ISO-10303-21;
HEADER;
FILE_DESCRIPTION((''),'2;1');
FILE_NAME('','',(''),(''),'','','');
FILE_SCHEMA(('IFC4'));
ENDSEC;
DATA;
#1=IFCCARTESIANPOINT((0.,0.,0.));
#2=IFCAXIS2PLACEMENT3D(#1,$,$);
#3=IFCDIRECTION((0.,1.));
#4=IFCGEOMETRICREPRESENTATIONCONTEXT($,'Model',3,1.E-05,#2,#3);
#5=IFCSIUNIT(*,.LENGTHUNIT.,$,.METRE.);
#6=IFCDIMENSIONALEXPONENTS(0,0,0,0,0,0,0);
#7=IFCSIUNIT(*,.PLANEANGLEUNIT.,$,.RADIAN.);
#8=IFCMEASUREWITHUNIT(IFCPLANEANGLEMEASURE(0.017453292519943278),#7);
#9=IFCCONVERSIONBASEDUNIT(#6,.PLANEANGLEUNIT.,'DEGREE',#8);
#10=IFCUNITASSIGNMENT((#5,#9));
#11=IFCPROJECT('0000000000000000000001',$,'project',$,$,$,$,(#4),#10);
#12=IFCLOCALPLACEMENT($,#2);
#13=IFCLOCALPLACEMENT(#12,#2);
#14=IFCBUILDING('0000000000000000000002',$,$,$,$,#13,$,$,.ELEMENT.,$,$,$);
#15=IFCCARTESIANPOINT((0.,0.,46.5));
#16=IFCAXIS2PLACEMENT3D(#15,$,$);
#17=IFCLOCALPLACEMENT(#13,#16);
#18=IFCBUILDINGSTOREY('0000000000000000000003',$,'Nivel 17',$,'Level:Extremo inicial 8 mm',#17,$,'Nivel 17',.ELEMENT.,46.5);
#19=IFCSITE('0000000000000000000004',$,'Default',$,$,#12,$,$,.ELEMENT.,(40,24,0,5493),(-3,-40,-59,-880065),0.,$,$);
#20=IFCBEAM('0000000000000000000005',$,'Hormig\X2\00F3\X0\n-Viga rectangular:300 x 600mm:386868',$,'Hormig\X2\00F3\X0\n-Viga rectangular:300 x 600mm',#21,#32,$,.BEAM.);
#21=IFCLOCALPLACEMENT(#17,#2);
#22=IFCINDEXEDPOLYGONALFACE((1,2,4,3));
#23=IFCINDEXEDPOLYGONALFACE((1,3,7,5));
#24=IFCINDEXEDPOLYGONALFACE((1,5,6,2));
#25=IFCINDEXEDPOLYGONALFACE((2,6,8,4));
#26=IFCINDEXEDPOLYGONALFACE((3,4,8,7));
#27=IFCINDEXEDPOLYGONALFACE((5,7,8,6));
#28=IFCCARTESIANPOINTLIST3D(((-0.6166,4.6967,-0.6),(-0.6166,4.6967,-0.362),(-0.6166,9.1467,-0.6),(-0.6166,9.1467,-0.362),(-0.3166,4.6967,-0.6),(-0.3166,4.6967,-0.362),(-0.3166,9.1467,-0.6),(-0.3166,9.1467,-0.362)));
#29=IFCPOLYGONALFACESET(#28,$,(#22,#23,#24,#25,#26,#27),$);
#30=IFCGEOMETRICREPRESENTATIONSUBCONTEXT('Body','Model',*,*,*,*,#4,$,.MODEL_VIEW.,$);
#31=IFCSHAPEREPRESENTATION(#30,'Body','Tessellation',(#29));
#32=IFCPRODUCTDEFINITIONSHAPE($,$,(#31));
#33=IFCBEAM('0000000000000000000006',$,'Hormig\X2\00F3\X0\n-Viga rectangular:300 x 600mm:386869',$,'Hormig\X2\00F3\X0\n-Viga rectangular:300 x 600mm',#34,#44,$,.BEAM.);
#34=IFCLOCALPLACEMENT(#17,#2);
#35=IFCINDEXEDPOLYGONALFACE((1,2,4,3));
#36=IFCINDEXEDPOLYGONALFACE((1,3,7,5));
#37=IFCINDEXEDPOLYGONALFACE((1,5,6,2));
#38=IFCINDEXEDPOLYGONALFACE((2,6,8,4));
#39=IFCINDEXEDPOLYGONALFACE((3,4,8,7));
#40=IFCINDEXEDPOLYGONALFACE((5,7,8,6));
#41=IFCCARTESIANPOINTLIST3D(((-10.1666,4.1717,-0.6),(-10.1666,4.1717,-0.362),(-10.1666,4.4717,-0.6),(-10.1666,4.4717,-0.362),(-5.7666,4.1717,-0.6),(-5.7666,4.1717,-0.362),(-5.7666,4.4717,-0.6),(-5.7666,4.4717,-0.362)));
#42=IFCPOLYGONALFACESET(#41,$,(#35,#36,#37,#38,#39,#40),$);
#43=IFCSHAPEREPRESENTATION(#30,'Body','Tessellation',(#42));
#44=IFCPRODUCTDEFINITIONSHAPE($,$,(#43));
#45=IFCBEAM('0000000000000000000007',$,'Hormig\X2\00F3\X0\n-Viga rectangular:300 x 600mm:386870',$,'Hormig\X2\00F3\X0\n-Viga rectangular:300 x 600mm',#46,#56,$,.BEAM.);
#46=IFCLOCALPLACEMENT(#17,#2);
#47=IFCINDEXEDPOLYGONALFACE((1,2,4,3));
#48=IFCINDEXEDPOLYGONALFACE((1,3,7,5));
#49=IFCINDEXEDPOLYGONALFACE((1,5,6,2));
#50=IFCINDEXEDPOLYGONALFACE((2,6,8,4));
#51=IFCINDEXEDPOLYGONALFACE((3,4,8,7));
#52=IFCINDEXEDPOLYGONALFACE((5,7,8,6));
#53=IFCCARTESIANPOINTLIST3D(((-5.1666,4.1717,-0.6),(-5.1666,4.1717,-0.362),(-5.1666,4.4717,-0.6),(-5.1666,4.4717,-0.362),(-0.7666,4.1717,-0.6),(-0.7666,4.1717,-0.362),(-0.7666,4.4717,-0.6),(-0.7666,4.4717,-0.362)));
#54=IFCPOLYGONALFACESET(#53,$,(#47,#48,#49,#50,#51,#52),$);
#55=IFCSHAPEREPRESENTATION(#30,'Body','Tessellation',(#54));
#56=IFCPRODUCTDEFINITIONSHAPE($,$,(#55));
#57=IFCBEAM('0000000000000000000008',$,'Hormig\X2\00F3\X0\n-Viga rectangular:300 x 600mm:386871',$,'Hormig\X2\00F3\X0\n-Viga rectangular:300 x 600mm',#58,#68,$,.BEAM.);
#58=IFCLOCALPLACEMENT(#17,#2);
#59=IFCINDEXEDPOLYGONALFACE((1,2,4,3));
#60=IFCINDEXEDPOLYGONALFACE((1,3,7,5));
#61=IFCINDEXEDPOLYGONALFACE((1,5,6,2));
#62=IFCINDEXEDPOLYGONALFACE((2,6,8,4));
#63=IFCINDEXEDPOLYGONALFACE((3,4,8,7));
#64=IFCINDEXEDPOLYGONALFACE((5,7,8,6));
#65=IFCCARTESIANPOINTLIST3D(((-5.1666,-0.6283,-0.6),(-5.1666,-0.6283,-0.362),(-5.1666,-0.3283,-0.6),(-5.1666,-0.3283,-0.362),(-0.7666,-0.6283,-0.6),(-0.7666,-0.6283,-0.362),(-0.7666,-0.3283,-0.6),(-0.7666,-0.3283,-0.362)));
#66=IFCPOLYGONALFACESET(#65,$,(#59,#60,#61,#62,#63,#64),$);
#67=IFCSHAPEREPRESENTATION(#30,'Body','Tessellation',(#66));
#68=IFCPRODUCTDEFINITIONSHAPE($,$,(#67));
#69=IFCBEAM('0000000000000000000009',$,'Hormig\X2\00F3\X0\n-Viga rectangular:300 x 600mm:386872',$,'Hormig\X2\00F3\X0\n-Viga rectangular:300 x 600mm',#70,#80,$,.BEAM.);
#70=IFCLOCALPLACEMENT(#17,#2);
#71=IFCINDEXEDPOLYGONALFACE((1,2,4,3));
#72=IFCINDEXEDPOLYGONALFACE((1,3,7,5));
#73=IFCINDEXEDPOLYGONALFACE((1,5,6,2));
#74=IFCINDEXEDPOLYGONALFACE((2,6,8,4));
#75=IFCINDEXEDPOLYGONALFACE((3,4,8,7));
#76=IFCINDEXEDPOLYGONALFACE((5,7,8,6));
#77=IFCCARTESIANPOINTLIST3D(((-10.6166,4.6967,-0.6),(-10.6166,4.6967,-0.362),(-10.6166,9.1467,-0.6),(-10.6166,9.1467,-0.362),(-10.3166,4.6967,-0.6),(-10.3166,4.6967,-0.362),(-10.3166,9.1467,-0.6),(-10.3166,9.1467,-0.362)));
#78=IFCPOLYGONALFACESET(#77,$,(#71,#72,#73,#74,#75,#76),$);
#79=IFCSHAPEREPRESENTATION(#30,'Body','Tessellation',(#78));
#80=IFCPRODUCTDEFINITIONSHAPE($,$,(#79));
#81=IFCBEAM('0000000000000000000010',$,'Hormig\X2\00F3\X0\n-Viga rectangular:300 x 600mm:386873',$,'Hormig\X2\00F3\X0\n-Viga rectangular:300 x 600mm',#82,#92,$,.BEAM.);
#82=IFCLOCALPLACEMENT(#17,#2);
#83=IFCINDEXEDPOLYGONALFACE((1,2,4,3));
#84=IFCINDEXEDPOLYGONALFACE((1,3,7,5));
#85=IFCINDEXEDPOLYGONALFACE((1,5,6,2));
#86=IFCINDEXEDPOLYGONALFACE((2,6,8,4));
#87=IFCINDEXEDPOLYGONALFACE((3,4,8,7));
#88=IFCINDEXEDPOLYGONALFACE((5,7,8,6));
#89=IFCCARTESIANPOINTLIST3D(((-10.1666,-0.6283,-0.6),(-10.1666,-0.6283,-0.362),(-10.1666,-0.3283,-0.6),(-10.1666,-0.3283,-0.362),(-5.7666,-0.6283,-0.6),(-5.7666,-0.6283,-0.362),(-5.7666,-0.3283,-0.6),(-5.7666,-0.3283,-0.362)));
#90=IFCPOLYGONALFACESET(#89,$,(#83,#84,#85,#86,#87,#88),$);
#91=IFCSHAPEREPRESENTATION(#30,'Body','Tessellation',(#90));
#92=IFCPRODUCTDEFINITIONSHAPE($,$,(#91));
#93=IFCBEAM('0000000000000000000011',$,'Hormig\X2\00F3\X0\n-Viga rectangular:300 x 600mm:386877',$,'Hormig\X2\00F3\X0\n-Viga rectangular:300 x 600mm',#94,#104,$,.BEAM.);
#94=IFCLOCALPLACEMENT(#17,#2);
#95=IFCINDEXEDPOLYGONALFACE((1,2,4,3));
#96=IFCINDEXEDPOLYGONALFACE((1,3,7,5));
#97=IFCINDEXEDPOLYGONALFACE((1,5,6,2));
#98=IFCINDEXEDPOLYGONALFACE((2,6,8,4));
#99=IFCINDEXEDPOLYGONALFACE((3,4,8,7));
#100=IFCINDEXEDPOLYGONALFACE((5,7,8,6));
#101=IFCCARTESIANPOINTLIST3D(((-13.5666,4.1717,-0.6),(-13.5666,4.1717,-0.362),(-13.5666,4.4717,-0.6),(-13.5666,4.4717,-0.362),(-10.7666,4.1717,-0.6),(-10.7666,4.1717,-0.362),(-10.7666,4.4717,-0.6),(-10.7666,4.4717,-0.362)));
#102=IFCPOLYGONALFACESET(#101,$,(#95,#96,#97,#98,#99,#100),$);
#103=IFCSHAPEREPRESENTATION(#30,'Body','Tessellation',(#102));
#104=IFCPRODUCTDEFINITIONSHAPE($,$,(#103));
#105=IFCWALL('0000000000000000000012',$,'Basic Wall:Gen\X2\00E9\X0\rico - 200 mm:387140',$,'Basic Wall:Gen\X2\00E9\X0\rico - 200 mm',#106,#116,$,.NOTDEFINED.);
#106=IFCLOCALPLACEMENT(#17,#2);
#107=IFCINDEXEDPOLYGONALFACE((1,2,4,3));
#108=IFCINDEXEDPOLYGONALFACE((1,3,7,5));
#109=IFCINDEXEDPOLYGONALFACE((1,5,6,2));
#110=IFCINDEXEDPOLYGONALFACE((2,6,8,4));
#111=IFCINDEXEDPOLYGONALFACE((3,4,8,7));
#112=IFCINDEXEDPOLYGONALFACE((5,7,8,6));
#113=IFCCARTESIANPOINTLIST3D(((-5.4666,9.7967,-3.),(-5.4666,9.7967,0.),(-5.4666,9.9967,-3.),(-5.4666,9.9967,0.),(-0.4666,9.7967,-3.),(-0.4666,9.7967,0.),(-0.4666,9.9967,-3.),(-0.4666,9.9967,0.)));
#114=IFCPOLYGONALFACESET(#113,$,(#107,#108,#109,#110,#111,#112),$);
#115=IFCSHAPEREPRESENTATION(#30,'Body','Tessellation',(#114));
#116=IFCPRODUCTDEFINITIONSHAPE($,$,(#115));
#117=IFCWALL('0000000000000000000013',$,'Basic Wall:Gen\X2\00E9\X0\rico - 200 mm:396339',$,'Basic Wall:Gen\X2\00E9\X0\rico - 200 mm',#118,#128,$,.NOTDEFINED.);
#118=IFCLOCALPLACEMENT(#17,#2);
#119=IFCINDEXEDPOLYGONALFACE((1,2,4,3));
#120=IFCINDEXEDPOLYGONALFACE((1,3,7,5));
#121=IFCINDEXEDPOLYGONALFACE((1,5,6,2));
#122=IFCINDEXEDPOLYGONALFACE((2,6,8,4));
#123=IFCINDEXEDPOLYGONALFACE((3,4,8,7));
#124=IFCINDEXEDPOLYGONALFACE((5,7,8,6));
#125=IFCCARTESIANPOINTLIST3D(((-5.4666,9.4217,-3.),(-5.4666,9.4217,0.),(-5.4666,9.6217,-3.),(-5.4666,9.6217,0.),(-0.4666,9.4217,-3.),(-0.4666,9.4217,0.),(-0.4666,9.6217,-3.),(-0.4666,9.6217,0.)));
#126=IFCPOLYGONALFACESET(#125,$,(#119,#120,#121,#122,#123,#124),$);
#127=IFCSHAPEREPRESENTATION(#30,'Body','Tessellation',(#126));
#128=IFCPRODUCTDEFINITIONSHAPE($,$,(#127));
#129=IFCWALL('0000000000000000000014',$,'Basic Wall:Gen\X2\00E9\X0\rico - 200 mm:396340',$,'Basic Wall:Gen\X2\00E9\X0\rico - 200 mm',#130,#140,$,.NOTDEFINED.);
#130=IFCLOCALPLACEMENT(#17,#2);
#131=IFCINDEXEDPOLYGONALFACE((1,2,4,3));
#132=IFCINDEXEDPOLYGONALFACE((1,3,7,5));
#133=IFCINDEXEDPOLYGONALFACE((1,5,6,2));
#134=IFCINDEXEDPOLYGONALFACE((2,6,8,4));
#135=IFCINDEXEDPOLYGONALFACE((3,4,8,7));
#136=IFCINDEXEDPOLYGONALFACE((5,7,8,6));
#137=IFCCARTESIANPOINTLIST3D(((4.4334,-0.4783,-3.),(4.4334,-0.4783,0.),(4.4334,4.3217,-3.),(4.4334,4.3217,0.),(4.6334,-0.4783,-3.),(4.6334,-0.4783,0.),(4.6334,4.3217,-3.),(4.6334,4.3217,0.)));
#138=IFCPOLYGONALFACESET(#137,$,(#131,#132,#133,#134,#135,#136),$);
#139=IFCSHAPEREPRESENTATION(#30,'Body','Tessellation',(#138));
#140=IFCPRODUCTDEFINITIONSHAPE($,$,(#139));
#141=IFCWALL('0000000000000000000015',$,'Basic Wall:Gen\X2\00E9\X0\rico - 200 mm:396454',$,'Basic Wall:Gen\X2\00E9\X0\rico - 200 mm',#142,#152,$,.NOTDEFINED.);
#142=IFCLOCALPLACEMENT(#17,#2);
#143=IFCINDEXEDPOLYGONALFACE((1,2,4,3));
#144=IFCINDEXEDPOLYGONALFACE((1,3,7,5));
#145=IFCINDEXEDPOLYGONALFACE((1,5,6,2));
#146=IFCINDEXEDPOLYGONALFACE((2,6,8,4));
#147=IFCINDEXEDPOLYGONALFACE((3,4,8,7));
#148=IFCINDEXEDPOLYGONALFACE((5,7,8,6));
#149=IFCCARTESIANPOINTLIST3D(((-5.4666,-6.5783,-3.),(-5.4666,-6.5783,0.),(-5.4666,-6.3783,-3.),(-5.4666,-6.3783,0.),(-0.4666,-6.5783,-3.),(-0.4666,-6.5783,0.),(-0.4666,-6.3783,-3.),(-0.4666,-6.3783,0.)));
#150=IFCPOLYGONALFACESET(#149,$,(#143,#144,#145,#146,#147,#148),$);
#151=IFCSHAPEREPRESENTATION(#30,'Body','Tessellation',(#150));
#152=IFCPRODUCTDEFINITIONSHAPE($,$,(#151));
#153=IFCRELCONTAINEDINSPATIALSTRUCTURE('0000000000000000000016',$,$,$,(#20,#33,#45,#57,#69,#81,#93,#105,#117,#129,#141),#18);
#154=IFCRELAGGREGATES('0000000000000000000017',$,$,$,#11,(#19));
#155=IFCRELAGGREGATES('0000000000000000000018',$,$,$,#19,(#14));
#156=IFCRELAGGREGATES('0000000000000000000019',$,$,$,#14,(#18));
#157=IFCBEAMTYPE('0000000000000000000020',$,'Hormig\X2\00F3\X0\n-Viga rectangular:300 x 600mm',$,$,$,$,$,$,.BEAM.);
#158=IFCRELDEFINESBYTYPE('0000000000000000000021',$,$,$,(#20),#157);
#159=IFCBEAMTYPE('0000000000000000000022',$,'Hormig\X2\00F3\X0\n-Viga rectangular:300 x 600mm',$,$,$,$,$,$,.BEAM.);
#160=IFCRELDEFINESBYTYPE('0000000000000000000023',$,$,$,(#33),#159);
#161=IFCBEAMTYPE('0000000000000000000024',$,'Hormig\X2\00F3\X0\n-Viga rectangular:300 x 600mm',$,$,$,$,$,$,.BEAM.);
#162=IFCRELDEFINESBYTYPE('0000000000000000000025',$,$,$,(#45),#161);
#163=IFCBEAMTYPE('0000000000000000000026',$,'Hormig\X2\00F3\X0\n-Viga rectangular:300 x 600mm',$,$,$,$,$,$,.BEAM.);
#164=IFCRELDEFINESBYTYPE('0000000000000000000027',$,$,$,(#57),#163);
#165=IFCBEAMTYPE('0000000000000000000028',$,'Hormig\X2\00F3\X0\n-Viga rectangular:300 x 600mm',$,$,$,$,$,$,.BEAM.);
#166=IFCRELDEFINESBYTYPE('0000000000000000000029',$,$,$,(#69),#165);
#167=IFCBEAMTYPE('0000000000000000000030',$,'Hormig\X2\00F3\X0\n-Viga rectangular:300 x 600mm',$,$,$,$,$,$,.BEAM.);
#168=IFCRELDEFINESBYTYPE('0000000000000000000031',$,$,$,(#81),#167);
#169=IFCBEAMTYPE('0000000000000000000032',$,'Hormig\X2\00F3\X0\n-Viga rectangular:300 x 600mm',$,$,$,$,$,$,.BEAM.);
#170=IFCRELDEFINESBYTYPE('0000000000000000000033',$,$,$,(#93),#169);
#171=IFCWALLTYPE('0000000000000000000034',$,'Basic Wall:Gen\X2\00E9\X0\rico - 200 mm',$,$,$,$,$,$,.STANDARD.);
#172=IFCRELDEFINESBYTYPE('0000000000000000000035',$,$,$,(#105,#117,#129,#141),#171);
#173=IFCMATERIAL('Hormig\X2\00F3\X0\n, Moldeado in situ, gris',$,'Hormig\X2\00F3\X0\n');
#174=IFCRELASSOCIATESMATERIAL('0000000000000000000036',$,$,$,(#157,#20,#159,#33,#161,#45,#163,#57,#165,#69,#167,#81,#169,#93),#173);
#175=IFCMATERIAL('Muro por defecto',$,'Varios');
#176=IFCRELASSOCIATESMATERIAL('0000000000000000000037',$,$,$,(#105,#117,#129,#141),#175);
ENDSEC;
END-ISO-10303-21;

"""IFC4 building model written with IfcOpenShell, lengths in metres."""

from ifc_helpers import new_model, entity, si_unit, converted_unit, direction, frame, origin, place, context, subcontext, project, spatial, indexed_curve, outline, extrude, source, transform, mapped, material, type_object, type_shapes, element, save


model = new_model("IFC4")

# Units and contexts
model_context = context("Model", 3, precision=1e-05, world=origin(), true_north=direction((0.0, 1.0)))
body_context = subcontext(model_context, "Body", "Model", "MODEL_VIEW")
ifc_project = project(units=[si_unit("LENGTHUNIT", "METRE"), converted_unit("PLANEANGLEUNIT", "DEGREE", entity("IfcPlaneAngleMeasure", 0.017453292519943278), si_unit("PLANEANGLEUNIT", "RADIAN"), dimensions=[0, 0, 0, 0, 0, 0, 0])], contexts=[model_context])

# Site, building, storey
site_placement = place(None, origin())
site = spatial("IfcSite", under=ifc_project, at=site_placement, Name="Default", CompositionType="ELEMENT", RefLatitude=(40, 24, 0, 5493), RefLongitude=(-3, -40, -59, -880065), RefElevation=0.0)
building_placement = place(site_placement, origin())
building = spatial("IfcBuilding", under=site, at=building_placement, CompositionType="ELEMENT")
storey_placement = place(building_placement, frame((0.0, 0.0, 46.5)))
storey = spatial("IfcBuildingStorey", under=building, at=storey_placement, Name="Nivel 17", ObjectType="Level:Extremo inicial 8 mm", LongName="Nivel 17", CompositionType="ELEMENT", Elevation=46.5)

# Beams
ifc_material_1 = material(Name="Hormigón, Moldeado in situ, gris", Category="Hormigón")
beam_type_1 = type_object("IfcBeamType", Name="Hormigón-Viga rectangular:300 x 600mm", PredefinedType="BEAM", material=ifc_material_1)
shared_shape_1 = source(origin(), body_context, "Body", "SweptSolid", [
    extrude(outline(indexed_curve([(-0.15, -0.119), (0.15, -0.119), (0.15, 0.119), (-0.15, 0.119), (-0.15, -0.119)], self_intersect=False)), frame((-0.4666, 9.1467, 46.019), z_axis=(0.0, -1.0, 0.0), x_axis=(-1.0, 0.0, 0.0)), (0.0, 0.0, 1.0), 4.45),
])
type_shapes(beam_type_1, [shared_shape_1])
beam_1_placement = place(storey_placement, frame((0.0, 0.0, -46.5)))
element("IfcBeam", 1, at=beam_1_placement, inside=storey, type_object=beam_type_1, material=ifc_material_1, Name="Hormigón-Viga rectangular:300 x 600mm:386868", ObjectType="Hormigón-Viga rectangular:300 x 600mm", PredefinedType="BEAM", context=body_context, shape_type="MappedRepresentation", body=[
    mapped(shared_shape_1, transform((0.0, 0.0, 0.0), scale=1.0)),
])
beam_type_2 = type_object("IfcBeamType", Name="Hormigón-Viga rectangular:300 x 600mm", PredefinedType="BEAM", material=ifc_material_1)
shared_shape_2 = source(origin(), body_context, "Body", "SweptSolid", [
    extrude(outline(indexed_curve([(-0.119, -0.15), (0.119, -0.15), (0.119, 0.15), (-0.119, 0.15), (-0.119, -0.15)], self_intersect=False)), frame((-10.1666, 4.3217, 46.019), z_axis=(1.0, 0.0, 0.0), x_axis=(0.0, 0.0, -1.0)), (0.0, 0.0, 1.0), 4.4),
])
type_shapes(beam_type_2, [shared_shape_2])
beam_2_placement = place(storey_placement, frame((0.0, 0.0, -46.5)))
element("IfcBeam", 2, at=beam_2_placement, inside=storey, type_object=beam_type_2, material=ifc_material_1, Name="Hormigón-Viga rectangular:300 x 600mm:386869", ObjectType="Hormigón-Viga rectangular:300 x 600mm", PredefinedType="BEAM", context=body_context, shape_type="MappedRepresentation", body=[
    mapped(shared_shape_2, transform((0.0, 0.0, 0.0), scale=1.0)),
])
beam_type_3 = type_object("IfcBeamType", Name="Hormigón-Viga rectangular:300 x 600mm", PredefinedType="BEAM", material=ifc_material_1)
shared_shape_3 = source(origin(), body_context, "Body", "SweptSolid", [
    extrude(outline(indexed_curve([(-0.119, -0.15), (0.119, -0.15), (0.119, 0.15), (-0.119, 0.15), (-0.119, -0.15)], self_intersect=False)), frame((-5.1666, 4.3217, 46.019), z_axis=(1.0, 0.0, 0.0), x_axis=(0.0, 0.0, -1.0)), (0.0, 0.0, 1.0), 4.4),
])
type_shapes(beam_type_3, [shared_shape_3])
beam_3_placement = place(storey_placement, frame((0.0, 0.0, -46.5)))
element("IfcBeam", 3, at=beam_3_placement, inside=storey, type_object=beam_type_3, material=ifc_material_1, Name="Hormigón-Viga rectangular:300 x 600mm:386870", ObjectType="Hormigón-Viga rectangular:300 x 600mm", PredefinedType="BEAM", context=body_context, shape_type="MappedRepresentation", body=[
    mapped(shared_shape_3, transform((0.0, 0.0, 0.0), scale=1.0)),
])
beam_type_4 = type_object("IfcBeamType", Name="Hormigón-Viga rectangular:300 x 600mm", PredefinedType="BEAM", material=ifc_material_1)
shared_shape_4 = source(origin(), body_context, "Body", "SweptSolid", [
    extrude(outline(indexed_curve([(-0.119, -0.15), (0.119, -0.15), (0.119, 0.15), (-0.119, 0.15), (-0.119, -0.15)], self_intersect=False)), frame((-0.7666, -0.4783, 46.019), z_axis=(-1.0, 0.0, 0.0), x_axis=(0.0, 0.0, -1.0)), (0.0, 0.0, 1.0), 4.4),
])
type_shapes(beam_type_4, [shared_shape_4])
beam_4_placement = place(storey_placement, frame((0.0, 0.0, -46.5)))
element("IfcBeam", 4, at=beam_4_placement, inside=storey, type_object=beam_type_4, material=ifc_material_1, Name="Hormigón-Viga rectangular:300 x 600mm:386871", ObjectType="Hormigón-Viga rectangular:300 x 600mm", PredefinedType="BEAM", context=body_context, shape_type="MappedRepresentation", body=[
    mapped(shared_shape_4, transform((0.0, 0.0, 0.0), scale=1.0)),
])
beam_type_5 = type_object("IfcBeamType", Name="Hormigón-Viga rectangular:300 x 600mm", PredefinedType="BEAM", material=ifc_material_1)
shared_shape_5 = source(origin(), body_context, "Body", "SweptSolid", [
    extrude(outline(indexed_curve([(-0.15, -0.119), (0.15, -0.119), (0.15, 0.119), (-0.15, 0.119), (-0.15, -0.119)], self_intersect=False)), frame((-10.4666, 4.6967, 46.019), z_axis=(0.0, 1.0, 0.0), x_axis=(-1.0, 0.0, 0.0)), (0.0, 0.0, 1.0), 4.45),
])
type_shapes(beam_type_5, [shared_shape_5])
beam_5_placement = place(storey_placement, frame((0.0, 0.0, -46.5)))
element("IfcBeam", 5, at=beam_5_placement, inside=storey, type_object=beam_type_5, material=ifc_material_1, Name="Hormigón-Viga rectangular:300 x 600mm:386872", ObjectType="Hormigón-Viga rectangular:300 x 600mm", PredefinedType="BEAM", context=body_context, shape_type="MappedRepresentation", body=[
    mapped(shared_shape_5, transform((0.0, 0.0, 0.0), scale=1.0)),
])
beam_type_6 = type_object("IfcBeamType", Name="Hormigón-Viga rectangular:300 x 600mm", PredefinedType="BEAM", material=ifc_material_1)
shared_shape_6 = source(origin(), body_context, "Body", "SweptSolid", [
    extrude(outline(indexed_curve([(-0.119, -0.15), (0.119, -0.15), (0.119, 0.15), (-0.119, 0.15), (-0.119, -0.15)], self_intersect=False)), frame((-10.1666, -0.4783, 46.019), z_axis=(1.0, 0.0, 0.0), x_axis=(0.0, 0.0, -1.0)), (0.0, 0.0, 1.0), 4.4),
])
type_shapes(beam_type_6, [shared_shape_6])
beam_6_placement = place(storey_placement, frame((0.0, 0.0, -46.5)))
element("IfcBeam", 6, at=beam_6_placement, inside=storey, type_object=beam_type_6, material=ifc_material_1, Name="Hormigón-Viga rectangular:300 x 600mm:386873", ObjectType="Hormigón-Viga rectangular:300 x 600mm", PredefinedType="BEAM", context=body_context, shape_type="MappedRepresentation", body=[
    mapped(shared_shape_6, transform((0.0, 0.0, 0.0), scale=1.0)),
])
beam_type_7 = type_object("IfcBeamType", Name="Hormigón-Viga rectangular:300 x 600mm", PredefinedType="BEAM", material=ifc_material_1)
shared_shape_7 = source(origin(), body_context, "Body", "SweptSolid", [
    extrude(outline(indexed_curve([(-0.119, -0.15), (0.119, -0.15), (0.119, 0.15), (-0.119, 0.15), (-0.119, -0.15)], self_intersect=False)), frame((-10.7666, 4.3217, 46.019), z_axis=(-1.0, 0.0, 0.0), x_axis=(0.0, 0.0, -1.0)), (0.0, 0.0, 1.0), 2.8),
])
type_shapes(beam_type_7, [shared_shape_7])
beam_7_placement = place(storey_placement, frame((0.0, 0.0, -46.5)))
element("IfcBeam", 7, at=beam_7_placement, inside=storey, type_object=beam_type_7, material=ifc_material_1, Name="Hormigón-Viga rectangular:300 x 600mm:386877", ObjectType="Hormigón-Viga rectangular:300 x 600mm", PredefinedType="BEAM", context=body_context, shape_type="MappedRepresentation", body=[
    mapped(shared_shape_7, transform((0.0, 0.0, 0.0), scale=1.0)),
])

# Walls
ifc_material_2 = material(Name="Muro por defecto", Category="Varios")
wall_type = type_object("IfcWallType", Name="Basic Wall:Genérico - 200 mm", PredefinedType="STANDARD")
wall_1_placement = place(storey_placement, frame((-5.4666, 9.8967, -3.0)))
element("IfcWall", 8, at=wall_1_placement, inside=storey, type_object=wall_type, material=ifc_material_2, Name="Basic Wall:Genérico - 200 mm:387140", ObjectType="Basic Wall:Genérico - 200 mm", PredefinedType="NOTDEFINED", context=body_context, shape_type="SweptSolid", body=[
    extrude(outline(indexed_curve([(5.0, 0.1), (0.0, 0.1), (0.0, -0.1), (5.0, -0.1), (5.0, 0.1)], self_intersect=False)), origin(), (0.0, 0.0, 1.0), 3.0),
])
wall_2_placement = place(storey_placement, frame((-5.4666, 9.5217, -3.0)))
element("IfcWall", 9, at=wall_2_placement, inside=storey, type_object=wall_type, material=ifc_material_2, Name="Basic Wall:Genérico - 200 mm:396339", ObjectType="Basic Wall:Genérico - 200 mm", PredefinedType="NOTDEFINED", context=body_context, shape_type="SweptSolid", body=[
    extrude(outline(indexed_curve([(5.0, 0.1), (0.0, 0.1), (0.0, -0.1), (5.0, -0.1), (5.0, 0.1)], self_intersect=False)), origin(), (0.0, 0.0, 1.0), 3.0),
])
wall_3_placement = place(storey_placement, frame((4.5334, 4.3217, -3.0), z_axis=(0.0, 0.0, 1.0), x_axis=(0.0, -1.0, 0.0)))
element("IfcWall", 10, at=wall_3_placement, inside=storey, type_object=wall_type, material=ifc_material_2, Name="Basic Wall:Genérico - 200 mm:396340", ObjectType="Basic Wall:Genérico - 200 mm", PredefinedType="NOTDEFINED", context=body_context, shape_type="SweptSolid", body=[
    extrude(outline(indexed_curve([(4.8, 0.1), (0.0, 0.1), (0.0, -0.1), (4.8, -0.1), (4.8, 0.1)], self_intersect=False)), origin(), (0.0, 0.0, 1.0), 3.0),
])
wall_4_placement = place(storey_placement, frame((-5.4666, -6.4783, -3.0)))
element("IfcWall", 11, at=wall_4_placement, inside=storey, type_object=wall_type, material=ifc_material_2, Name="Basic Wall:Genérico - 200 mm:396454", ObjectType="Basic Wall:Genérico - 200 mm", PredefinedType="NOTDEFINED", context=body_context, shape_type="SweptSolid", body=[
    extrude(outline(indexed_curve([(5.0, 0.1), (0.0, 0.1), (0.0, -0.1), (5.0, -0.1), (5.0, 0.1)], self_intersect=False)), origin(), (0.0, 0.0, 1.0), 3.0),
])

save(model, "model.ifc")
